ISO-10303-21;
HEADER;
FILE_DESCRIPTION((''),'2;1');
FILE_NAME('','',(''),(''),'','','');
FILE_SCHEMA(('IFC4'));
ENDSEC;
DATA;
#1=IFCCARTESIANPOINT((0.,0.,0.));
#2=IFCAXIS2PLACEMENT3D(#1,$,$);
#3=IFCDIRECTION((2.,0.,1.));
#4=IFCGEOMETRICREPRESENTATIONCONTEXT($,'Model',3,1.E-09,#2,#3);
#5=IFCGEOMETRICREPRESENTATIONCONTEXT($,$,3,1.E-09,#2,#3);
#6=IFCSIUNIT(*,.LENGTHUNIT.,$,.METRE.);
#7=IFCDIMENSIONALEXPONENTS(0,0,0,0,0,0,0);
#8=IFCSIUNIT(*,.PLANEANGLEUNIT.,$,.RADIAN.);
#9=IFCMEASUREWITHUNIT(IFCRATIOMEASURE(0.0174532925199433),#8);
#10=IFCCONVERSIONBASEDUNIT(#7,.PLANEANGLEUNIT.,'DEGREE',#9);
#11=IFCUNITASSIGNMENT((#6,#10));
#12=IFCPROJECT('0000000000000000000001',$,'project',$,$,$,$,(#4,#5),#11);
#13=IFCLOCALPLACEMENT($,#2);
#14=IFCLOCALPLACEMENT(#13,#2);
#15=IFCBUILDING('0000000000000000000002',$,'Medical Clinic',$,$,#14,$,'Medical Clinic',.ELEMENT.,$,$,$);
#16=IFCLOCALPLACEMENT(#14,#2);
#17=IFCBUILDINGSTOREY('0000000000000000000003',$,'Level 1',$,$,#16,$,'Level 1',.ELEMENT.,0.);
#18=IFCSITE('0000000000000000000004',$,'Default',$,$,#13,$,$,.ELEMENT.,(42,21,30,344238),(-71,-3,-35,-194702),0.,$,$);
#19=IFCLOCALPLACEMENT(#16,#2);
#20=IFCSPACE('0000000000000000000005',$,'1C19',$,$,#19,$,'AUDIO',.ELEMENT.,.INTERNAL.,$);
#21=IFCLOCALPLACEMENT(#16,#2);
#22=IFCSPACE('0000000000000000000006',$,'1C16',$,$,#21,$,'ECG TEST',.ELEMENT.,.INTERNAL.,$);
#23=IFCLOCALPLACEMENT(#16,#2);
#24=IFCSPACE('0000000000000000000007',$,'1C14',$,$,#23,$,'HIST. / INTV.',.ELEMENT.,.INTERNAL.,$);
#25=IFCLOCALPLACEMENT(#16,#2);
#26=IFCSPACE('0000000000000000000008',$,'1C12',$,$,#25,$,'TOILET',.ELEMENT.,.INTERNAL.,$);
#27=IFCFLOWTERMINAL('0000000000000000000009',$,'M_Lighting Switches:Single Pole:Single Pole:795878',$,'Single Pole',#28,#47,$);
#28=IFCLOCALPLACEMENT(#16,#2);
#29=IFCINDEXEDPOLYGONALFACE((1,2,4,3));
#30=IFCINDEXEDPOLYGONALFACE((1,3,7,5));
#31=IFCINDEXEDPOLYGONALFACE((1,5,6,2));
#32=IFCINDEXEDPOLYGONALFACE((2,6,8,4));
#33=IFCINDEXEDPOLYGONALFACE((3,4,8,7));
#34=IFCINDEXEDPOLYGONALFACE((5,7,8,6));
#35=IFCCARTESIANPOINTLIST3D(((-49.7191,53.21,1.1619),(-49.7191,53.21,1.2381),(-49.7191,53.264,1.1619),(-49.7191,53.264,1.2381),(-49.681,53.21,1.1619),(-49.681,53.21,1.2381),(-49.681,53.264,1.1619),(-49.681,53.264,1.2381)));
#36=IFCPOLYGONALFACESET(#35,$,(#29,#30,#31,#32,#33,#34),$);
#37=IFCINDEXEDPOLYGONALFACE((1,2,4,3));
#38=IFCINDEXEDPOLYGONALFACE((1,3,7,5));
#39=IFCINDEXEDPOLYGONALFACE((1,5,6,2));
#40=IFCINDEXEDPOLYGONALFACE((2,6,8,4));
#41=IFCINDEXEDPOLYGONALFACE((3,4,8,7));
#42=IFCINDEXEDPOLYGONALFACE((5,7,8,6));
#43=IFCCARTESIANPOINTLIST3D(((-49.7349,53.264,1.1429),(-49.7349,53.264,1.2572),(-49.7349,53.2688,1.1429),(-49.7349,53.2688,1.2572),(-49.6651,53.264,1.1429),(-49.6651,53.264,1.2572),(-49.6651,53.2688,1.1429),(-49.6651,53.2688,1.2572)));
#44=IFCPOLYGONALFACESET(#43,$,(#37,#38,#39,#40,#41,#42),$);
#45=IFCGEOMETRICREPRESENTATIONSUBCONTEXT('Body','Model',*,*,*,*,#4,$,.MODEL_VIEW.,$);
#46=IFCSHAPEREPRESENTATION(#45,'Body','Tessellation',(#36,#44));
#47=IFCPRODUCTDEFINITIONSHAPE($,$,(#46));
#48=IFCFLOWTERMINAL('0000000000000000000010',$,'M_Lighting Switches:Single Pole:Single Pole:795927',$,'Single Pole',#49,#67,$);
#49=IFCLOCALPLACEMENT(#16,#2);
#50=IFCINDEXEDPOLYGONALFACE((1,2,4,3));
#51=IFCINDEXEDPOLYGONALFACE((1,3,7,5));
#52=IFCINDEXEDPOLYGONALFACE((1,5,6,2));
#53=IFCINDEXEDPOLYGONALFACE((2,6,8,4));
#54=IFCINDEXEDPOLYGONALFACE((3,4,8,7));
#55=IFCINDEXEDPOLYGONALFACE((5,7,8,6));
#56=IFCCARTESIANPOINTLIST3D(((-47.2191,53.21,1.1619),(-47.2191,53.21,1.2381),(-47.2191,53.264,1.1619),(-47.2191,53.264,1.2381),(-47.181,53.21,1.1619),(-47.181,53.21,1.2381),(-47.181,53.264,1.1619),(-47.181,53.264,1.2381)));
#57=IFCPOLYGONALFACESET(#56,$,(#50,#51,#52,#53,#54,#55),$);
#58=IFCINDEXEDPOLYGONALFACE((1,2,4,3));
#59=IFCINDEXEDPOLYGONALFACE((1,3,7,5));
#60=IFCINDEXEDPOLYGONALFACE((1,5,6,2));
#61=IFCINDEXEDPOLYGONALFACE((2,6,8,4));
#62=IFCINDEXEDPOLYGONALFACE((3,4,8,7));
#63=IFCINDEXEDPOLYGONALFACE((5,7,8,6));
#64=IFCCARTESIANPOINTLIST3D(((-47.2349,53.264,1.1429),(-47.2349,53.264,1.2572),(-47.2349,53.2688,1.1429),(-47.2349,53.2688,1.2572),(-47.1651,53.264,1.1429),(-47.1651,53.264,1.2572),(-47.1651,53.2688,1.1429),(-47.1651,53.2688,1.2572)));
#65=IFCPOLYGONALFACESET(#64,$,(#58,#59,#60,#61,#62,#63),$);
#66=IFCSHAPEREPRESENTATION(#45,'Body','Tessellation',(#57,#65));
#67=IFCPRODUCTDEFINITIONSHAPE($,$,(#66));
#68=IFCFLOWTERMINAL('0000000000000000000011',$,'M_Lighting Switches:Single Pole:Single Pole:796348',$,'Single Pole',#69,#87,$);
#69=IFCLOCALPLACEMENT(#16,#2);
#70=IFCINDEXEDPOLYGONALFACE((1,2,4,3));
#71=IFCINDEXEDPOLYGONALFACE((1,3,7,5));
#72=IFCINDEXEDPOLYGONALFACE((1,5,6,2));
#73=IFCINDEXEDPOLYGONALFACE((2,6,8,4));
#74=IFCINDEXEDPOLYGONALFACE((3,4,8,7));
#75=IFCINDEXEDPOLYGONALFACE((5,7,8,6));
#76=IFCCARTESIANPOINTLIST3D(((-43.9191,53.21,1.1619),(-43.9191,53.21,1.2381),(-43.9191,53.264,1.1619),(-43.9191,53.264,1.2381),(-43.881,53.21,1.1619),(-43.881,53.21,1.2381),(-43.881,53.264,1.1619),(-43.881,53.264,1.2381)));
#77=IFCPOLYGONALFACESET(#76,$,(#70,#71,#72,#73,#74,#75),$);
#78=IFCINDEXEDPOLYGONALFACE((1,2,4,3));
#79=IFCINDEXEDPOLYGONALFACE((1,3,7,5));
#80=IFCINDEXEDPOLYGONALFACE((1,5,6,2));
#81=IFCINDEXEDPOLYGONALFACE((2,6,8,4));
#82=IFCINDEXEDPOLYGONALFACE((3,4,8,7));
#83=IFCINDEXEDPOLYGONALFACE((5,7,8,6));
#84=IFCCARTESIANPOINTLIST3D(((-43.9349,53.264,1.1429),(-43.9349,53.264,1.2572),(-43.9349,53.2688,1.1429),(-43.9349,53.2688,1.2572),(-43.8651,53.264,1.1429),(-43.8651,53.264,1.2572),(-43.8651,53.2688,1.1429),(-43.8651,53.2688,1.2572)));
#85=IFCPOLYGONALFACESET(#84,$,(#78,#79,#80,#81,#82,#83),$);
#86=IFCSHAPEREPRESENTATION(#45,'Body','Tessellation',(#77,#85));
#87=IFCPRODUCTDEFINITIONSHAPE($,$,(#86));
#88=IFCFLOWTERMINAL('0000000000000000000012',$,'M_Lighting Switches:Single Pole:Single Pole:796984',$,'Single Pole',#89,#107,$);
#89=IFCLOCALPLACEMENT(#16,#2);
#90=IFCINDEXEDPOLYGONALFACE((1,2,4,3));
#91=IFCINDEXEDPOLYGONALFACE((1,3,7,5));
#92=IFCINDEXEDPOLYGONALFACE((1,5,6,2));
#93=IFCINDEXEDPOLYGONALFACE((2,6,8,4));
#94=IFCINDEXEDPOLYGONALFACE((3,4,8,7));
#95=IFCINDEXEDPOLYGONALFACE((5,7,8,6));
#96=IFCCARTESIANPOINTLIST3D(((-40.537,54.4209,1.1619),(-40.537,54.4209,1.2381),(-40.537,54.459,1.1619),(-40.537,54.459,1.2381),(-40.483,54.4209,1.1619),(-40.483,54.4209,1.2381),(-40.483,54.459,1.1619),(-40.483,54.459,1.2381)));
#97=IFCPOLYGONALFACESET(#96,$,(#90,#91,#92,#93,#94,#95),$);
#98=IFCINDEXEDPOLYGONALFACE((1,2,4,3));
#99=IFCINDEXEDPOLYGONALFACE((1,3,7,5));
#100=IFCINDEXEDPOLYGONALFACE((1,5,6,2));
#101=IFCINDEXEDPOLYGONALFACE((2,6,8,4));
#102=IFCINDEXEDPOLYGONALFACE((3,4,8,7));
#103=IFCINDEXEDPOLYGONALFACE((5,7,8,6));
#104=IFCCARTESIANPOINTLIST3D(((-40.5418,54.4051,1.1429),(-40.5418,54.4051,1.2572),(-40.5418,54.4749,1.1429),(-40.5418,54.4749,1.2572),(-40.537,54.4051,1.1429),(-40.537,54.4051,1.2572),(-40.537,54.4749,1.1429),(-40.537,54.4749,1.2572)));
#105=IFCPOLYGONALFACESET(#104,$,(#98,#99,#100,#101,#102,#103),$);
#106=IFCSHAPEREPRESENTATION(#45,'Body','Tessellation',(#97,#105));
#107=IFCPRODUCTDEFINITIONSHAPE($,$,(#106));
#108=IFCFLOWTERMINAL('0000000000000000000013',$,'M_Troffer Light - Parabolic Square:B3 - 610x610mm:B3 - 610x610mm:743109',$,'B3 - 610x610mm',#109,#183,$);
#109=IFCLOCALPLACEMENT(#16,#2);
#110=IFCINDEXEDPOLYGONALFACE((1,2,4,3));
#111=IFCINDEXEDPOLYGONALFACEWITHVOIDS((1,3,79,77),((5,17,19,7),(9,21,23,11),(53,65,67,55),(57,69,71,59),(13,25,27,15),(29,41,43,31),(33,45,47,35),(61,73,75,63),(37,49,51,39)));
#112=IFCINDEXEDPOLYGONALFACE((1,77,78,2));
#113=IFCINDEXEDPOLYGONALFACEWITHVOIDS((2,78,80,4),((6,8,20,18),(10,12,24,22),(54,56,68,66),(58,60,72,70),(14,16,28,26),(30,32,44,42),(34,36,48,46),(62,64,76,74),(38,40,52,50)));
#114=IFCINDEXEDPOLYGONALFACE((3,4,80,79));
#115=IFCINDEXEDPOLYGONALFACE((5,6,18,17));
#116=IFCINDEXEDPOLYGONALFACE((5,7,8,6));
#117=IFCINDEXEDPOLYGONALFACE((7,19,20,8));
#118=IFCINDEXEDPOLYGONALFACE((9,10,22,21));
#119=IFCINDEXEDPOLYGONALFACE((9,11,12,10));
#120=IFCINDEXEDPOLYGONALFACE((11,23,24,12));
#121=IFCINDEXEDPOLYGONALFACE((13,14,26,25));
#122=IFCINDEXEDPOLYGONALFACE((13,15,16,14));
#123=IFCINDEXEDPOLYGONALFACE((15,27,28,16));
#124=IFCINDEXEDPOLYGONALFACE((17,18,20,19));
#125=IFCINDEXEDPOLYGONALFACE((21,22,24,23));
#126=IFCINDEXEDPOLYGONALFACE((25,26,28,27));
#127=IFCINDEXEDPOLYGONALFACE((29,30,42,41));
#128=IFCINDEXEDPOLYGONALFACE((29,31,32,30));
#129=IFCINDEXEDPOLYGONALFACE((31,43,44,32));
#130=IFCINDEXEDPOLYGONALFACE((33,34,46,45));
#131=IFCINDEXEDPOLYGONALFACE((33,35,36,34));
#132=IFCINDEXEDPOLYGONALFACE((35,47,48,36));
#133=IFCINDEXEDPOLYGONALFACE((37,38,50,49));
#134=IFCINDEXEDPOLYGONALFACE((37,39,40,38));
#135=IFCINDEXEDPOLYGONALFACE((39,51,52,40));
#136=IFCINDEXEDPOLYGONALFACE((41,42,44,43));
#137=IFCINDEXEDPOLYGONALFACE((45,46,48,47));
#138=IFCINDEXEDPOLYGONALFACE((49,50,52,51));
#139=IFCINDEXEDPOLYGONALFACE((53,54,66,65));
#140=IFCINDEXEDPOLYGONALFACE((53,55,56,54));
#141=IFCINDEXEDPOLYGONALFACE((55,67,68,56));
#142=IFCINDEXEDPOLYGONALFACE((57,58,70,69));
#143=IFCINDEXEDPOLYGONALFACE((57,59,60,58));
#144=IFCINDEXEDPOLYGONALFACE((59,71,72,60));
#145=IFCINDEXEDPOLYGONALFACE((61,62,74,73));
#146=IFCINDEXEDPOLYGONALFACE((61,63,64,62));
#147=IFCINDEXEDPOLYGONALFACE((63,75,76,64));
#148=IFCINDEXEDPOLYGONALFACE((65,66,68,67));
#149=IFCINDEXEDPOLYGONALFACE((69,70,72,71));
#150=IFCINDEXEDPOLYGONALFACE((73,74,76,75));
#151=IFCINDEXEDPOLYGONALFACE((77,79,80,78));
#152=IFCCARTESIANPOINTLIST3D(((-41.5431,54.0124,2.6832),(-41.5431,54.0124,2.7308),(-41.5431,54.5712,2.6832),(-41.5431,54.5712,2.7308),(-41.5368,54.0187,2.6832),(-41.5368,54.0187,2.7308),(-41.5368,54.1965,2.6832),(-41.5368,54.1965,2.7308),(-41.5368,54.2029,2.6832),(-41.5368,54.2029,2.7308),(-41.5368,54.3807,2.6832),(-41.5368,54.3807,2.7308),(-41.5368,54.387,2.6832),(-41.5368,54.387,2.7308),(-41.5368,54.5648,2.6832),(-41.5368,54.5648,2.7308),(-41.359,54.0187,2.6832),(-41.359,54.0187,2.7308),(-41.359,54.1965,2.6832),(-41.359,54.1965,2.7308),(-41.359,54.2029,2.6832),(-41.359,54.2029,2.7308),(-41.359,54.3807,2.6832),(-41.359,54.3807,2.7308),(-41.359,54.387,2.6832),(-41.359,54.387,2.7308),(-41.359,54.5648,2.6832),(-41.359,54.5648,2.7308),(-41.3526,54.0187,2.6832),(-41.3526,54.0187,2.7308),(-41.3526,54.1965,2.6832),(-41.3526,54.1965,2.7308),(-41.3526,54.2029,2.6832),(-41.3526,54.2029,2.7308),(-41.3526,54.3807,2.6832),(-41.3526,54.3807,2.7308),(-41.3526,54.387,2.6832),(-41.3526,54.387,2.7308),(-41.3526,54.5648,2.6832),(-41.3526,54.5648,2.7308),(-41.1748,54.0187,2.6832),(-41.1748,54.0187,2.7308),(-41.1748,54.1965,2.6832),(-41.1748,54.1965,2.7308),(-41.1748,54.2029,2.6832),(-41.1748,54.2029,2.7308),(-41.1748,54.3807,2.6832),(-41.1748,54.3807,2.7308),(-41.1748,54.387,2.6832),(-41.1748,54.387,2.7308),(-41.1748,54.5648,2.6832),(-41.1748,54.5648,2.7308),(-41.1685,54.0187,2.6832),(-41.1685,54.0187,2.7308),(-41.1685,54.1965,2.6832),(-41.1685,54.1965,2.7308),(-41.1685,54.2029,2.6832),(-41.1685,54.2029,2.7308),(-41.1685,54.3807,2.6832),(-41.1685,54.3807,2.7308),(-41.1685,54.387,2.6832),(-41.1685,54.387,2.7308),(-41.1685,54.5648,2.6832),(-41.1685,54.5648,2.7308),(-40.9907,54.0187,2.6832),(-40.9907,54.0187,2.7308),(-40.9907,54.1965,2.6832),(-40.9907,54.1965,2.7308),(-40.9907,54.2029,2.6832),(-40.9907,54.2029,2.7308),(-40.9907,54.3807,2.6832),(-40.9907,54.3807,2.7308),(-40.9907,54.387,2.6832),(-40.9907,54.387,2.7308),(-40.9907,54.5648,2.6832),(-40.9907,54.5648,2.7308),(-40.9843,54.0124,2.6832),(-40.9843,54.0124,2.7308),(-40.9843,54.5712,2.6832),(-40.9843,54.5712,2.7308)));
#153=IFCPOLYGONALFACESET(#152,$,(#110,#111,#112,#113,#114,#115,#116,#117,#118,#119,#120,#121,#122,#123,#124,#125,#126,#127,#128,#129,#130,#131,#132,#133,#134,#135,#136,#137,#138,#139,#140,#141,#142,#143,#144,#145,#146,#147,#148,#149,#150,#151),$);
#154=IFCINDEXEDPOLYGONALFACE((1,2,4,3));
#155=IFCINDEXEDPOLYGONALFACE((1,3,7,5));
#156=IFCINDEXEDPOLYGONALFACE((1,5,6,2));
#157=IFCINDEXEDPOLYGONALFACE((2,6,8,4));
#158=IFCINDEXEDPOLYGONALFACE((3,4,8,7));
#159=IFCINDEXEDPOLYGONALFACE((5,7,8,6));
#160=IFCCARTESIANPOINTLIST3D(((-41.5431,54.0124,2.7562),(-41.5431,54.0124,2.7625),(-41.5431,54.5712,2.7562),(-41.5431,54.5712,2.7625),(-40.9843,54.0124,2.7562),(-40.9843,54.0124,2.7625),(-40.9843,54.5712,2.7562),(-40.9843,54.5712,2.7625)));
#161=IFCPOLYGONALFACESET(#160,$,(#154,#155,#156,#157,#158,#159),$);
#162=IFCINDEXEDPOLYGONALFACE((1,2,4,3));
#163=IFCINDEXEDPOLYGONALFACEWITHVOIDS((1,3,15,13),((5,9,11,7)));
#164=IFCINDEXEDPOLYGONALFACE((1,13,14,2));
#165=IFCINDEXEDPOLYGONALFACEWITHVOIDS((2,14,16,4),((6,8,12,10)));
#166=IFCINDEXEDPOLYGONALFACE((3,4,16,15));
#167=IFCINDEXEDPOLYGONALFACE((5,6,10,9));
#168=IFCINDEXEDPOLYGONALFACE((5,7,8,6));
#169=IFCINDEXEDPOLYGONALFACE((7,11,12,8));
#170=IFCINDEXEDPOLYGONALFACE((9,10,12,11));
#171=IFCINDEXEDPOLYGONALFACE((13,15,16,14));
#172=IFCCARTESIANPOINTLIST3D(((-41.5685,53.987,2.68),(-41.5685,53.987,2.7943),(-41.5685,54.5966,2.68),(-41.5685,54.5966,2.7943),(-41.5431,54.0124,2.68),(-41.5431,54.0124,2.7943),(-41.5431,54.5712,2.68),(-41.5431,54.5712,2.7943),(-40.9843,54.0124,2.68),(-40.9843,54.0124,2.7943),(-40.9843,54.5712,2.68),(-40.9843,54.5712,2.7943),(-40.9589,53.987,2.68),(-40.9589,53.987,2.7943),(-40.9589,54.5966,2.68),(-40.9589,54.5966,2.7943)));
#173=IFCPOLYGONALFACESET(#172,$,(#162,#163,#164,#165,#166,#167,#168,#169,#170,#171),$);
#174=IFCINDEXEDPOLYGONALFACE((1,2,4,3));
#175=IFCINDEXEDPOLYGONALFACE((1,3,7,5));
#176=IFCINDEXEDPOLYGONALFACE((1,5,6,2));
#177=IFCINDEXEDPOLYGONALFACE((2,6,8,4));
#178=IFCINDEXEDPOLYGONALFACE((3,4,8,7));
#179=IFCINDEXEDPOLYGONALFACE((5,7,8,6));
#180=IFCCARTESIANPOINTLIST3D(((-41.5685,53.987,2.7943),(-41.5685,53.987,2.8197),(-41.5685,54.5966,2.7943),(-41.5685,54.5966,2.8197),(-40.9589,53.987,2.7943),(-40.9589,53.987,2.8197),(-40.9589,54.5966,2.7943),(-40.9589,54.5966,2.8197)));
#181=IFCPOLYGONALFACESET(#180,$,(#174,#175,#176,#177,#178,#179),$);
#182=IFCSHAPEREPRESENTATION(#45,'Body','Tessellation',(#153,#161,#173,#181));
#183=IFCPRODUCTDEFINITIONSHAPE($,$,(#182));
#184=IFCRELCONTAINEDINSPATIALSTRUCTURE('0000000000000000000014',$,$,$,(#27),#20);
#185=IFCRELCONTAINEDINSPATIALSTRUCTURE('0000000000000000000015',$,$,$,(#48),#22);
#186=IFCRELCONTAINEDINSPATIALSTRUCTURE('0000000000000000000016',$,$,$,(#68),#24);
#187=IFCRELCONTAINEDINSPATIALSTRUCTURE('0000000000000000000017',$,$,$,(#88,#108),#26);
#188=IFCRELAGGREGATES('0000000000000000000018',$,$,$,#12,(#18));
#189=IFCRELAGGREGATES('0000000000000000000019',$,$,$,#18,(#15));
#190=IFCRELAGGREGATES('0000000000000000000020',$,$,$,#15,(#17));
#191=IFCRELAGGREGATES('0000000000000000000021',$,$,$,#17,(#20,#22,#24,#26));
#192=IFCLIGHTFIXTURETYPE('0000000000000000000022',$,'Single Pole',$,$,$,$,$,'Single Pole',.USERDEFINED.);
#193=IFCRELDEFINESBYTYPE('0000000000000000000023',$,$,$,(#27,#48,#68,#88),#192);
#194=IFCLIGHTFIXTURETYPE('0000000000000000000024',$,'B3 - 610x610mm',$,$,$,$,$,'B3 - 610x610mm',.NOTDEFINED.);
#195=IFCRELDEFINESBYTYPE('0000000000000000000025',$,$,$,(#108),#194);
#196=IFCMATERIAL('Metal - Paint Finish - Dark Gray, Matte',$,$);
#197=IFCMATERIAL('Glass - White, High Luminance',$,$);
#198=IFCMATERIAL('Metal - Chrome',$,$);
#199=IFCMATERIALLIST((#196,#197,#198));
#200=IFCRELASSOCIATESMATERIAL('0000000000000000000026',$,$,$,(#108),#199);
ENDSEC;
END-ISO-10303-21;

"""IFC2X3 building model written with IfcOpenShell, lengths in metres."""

from ifc_helpers import new_model, entity, si_unit, converted_unit, direction, frame, frame_2d, origin, origin_2d_with_axis, place, context, subcontext, project, spatial, polyline, rectangle, outline, extrude, source, transform, mapped, material, material_list, type_object, type_shapes, element, save


model = new_model("IFC2X3")

# Units and contexts
model_context = context("Model", 3, precision=1e-09, world=origin(), true_north=direction((2.0, 0.0, 1.0)))
context_of_model = context(None, 3, precision=1e-09, world=origin(), true_north=direction((2.0, 0.0, 1.0)))
body_context = subcontext(model_context, "Body", "Model", "MODEL_VIEW")
ifc_project = project(units=[si_unit("LENGTHUNIT", "METRE"), converted_unit("PLANEANGLEUNIT", "DEGREE", entity("IfcRatioMeasure", 0.0174532925199433), si_unit("PLANEANGLEUNIT", "RADIAN"), dimensions=[0, 0, 0, 0, 0, 0, 0])], contexts=[model_context, context_of_model])

# Site, building, storey, space
site_placement = place(None, origin())
site = spatial("IfcSite", under=ifc_project, at=site_placement, Name="Default", CompositionType="ELEMENT", RefLatitude=(42, 21, 30, 344238), RefLongitude=(-71, -3, -35, -194702), RefElevation=0.0)
building_placement = place(site_placement, origin())
building = spatial("IfcBuilding", under=site, at=building_placement, Name="Medical Clinic", LongName="Medical Clinic", CompositionType="ELEMENT")
storey_placement = place(building_placement, origin())
storey = spatial("IfcBuildingStorey", under=building, at=storey_placement, Name="Level 1", LongName="Level 1", CompositionType="ELEMENT", Elevation=0.0)
space_1_placement = place(storey_placement, origin())
space_1 = spatial("IfcSpace", under=storey, at=space_1_placement, Name="1C19", LongName="AUDIO", CompositionType="ELEMENT", InteriorOrExteriorSpace="INTERNAL")

# Shared definitions
space_2_placement = place(storey_placement, origin())
space_2 = spatial("IfcSpace", under=storey, at=space_2_placement, Name="1C16", LongName="ECG TEST", CompositionType="ELEMENT", InteriorOrExteriorSpace="INTERNAL")

# Shared definitions
space_3_placement = place(storey_placement, origin())
space_3 = spatial("IfcSpace", under=storey, at=space_3_placement, Name="1C14", LongName="HIST. / INTV.", CompositionType="ELEMENT", InteriorOrExteriorSpace="INTERNAL")

# Shared definitions
space_4_placement = place(storey_placement, origin())
space_4 = spatial("IfcSpace", under=storey, at=space_4_placement, Name="1C12", LongName="TOILET", CompositionType="ELEMENT", InteriorOrExteriorSpace="INTERNAL")

# Flow terminals
light_fixture_type_1 = type_object("IfcLightFixtureType", Name="Single Pole", ElementType="Single Pole", PredefinedType="USERDEFINED")
shared_shape_1 = source(origin(), body_context, "Body", "SweptSolid", [
    extrude(rectangle(XDim=0.0381, YDim=0.0762, at=origin_2d_with_axis()), frame((0.0, 0.0, -0.054), z_axis=(0.0, 0.0, 1.0), x_axis=(-1.0, 0.0, 0.0)), (0.0, 0.0, 1.0), 0.054),
    extrude(rectangle(XDim=0.0698, YDim=0.1143, at=frame_2d((0.0, 0.0), x_axis=(1.0, 0.0))), frame((0.0, 0.0, 0.0), z_axis=(0.0, 0.0, 1.0), x_axis=(-1.0, 0.0, 0.0)), (0.0, 0.0, 1.0), 0.0048),
])
type_shapes(light_fixture_type_1, [shared_shape_1])
flow_terminal_1_placement = place(space_1_placement, frame((-49.7, 53.264, 1.2), z_axis=(0.0, 1.0, 0.0), x_axis=(-1.0, 0.0, 0.0)))
element("IfcFlowTerminal", 1, at=flow_terminal_1_placement, inside=space_1, type_object=light_fixture_type_1, Name="M_Lighting Switches:Single Pole:Single Pole:795878", ObjectType="Single Pole", context=body_context, shape_type="MappedRepresentation", body=[
    mapped(shared_shape_1, transform((0.0, 0.0, 0.0), scale=1.0)),
])
flow_terminal_2_placement = place(space_2_placement, frame((-47.2, 53.264, 1.2), z_axis=(0.0, 1.0, 0.0), x_axis=(-1.0, 0.0, 0.0)))
element("IfcFlowTerminal", 2, at=flow_terminal_2_placement, inside=space_2, type_object=light_fixture_type_1, Name="M_Lighting Switches:Single Pole:Single Pole:795927", ObjectType="Single Pole", context=body_context, shape_type="MappedRepresentation", body=[
    mapped(shared_shape_1, transform((0.0, 0.0, 0.0), scale=1.0)),
])
flow_terminal_3_placement = place(space_3_placement, frame((-43.9, 53.264, 1.2), z_axis=(0.0, 1.0, 0.0), x_axis=(-1.0, 0.0, 0.0)))
element("IfcFlowTerminal", 3, at=flow_terminal_3_placement, inside=space_3, type_object=light_fixture_type_1, Name="M_Lighting Switches:Single Pole:Single Pole:796348", ObjectType="Single Pole", context=body_context, shape_type="MappedRepresentation", body=[
    mapped(shared_shape_1, transform((0.0, 0.0, 0.0), scale=1.0)),
])
flow_terminal_4_placement = place(space_4_placement, frame((-40.537, 54.44, 1.2), z_axis=(-1.0, 0.0, 0.0), x_axis=(0.0, -1.0, 0.0)))
element("IfcFlowTerminal", 4, at=flow_terminal_4_placement, inside=space_4, type_object=light_fixture_type_1, Name="M_Lighting Switches:Single Pole:Single Pole:796984", ObjectType="Single Pole", context=body_context, shape_type="MappedRepresentation", body=[
    mapped(shared_shape_1, transform((0.0, 0.0, 0.0), scale=1.0)),
])
ifc_material_1 = material(Name="Metal - Paint Finish - Dark Gray, Matte")
ifc_material_2 = material(Name="Glass - White, High Luminance")
ifc_material_3 = material(Name="Metal - Chrome")
ifc_material_list = material_list([ifc_material_1, ifc_material_2, ifc_material_3])
light_fixture_type_2 = type_object("IfcLightFixtureType", Name="B3 - 610x610mm", ElementType="B3 - 610x610mm", PredefinedType="NOTDEFINED")
shared_shape_2 = source(origin(), body_context, "Body", "SweptSolid", [
    extrude(outline(polyline([(-0.2794, -0.2794), (0.2794, -0.2794), (0.2794, 0.2794), (-0.2794, 0.2794), (-0.2794, -0.2794)]), holes=[polyline([(-0.0952, 0.0953), (-0.273, 0.0953), (-0.273, 0.2731), (-0.0952, 0.2731), (-0.0952, 0.0953)]), polyline([(0.2731, 0.0953), (0.0953, 0.0953), (0.0953, 0.2731), (0.2731, 0.2731), (0.2731, 0.0953)]), polyline([(-0.0889, 0.2731), (0.0889, 0.2731), (0.0889, 0.0953), (-0.0889, 0.0953), (-0.0889, 0.2731)]), polyline([(0.2731, -0.273), (0.0953, -0.273), (0.0953, -0.0952), (0.2731, -0.0952), (0.2731, -0.273)]), polyline([(0.0889, -0.273), (-0.0889, -0.273), (-0.0889, -0.0952), (0.0889, -0.0952), (0.0889, -0.273)]), polyline([(-0.0952, -0.273), (-0.273, -0.273), (-0.273, -0.0952), (-0.0952, -0.0952), (-0.0952, -0.273)]), polyline([(-0.0952, -0.0889), (-0.273, -0.0889), (-0.273, 0.0889), (-0.0952, 0.0889), (-0.0952, -0.0889)]), polyline([(0.0889, -0.0889), (-0.0889, -0.0889), (-0.0889, 0.0889), (0.0889, 0.0889), (0.0889, -0.0889)]), polyline([(0.2731, -0.0889), (0.0953, -0.0889), (0.0953, 0.0889), (0.2731, 0.0889), (0.2731, -0.0889)])]), frame((0.0, -0.3048, -0.0508), z_axis=(0.0, 0.0, 1.0), x_axis=(-1.0, 0.0, 0.0)), (0.0, 0.0, 1.0), 0.0476),
    extrude(rectangle(XDim=0.5588, YDim=0.5588, at=origin_2d_with_axis()), frame((0.0, -0.3048, -0.0825), z_axis=(0.0, 0.0, 1.0), x_axis=(-1.0, 0.0, 0.0)), (0.0, 0.0, 1.0), 0.0064),
    extrude(outline(polyline([(-0.3048, -0.3048), (0.3048, -0.3048), (0.3048, 0.3048), (-0.3048, 0.3048), (-0.3048, -0.3048)]), holes=[polyline([(0.2794, 0.2794), (0.2794, -0.2794), (-0.2794, -0.2794), (-0.2794, 0.2794), (0.2794, 0.2794)])]), frame((0.0, -0.3048, -0.1143)), (0.0, 0.0, 1.0), 0.1143),
    extrude(rectangle(XDim=0.6096, YDim=0.6096, at=origin_2d_with_axis()), frame((0.0, -0.3048, -0.1397), z_axis=(0.0, 0.0, 1.0), x_axis=(-1.0, 0.0, 0.0)), (0.0, 0.0, 1.0), 0.0254),
])
type_shapes(light_fixture_type_2, [shared_shape_2])
flow_terminal_5_placement = place(space_4_placement, frame((-41.2637, 53.987, 2.68), z_axis=(0.0, 0.0, -1.0), x_axis=(1.0, 0.0, 0.0)))
element("IfcFlowTerminal", 5, at=flow_terminal_5_placement, inside=space_4, type_object=light_fixture_type_2, material=ifc_material_list, Name="M_Troffer Light - Parabolic Square:B3 - 610x610mm:B3 - 610x610mm:743109", ObjectType="B3 - 610x610mm", context=body_context, shape_type="MappedRepresentation", body=[
    mapped(shared_shape_2, transform((0.0, 0.0, 0.0), scale=1.0)),
])

save(model, "model.ifc")
